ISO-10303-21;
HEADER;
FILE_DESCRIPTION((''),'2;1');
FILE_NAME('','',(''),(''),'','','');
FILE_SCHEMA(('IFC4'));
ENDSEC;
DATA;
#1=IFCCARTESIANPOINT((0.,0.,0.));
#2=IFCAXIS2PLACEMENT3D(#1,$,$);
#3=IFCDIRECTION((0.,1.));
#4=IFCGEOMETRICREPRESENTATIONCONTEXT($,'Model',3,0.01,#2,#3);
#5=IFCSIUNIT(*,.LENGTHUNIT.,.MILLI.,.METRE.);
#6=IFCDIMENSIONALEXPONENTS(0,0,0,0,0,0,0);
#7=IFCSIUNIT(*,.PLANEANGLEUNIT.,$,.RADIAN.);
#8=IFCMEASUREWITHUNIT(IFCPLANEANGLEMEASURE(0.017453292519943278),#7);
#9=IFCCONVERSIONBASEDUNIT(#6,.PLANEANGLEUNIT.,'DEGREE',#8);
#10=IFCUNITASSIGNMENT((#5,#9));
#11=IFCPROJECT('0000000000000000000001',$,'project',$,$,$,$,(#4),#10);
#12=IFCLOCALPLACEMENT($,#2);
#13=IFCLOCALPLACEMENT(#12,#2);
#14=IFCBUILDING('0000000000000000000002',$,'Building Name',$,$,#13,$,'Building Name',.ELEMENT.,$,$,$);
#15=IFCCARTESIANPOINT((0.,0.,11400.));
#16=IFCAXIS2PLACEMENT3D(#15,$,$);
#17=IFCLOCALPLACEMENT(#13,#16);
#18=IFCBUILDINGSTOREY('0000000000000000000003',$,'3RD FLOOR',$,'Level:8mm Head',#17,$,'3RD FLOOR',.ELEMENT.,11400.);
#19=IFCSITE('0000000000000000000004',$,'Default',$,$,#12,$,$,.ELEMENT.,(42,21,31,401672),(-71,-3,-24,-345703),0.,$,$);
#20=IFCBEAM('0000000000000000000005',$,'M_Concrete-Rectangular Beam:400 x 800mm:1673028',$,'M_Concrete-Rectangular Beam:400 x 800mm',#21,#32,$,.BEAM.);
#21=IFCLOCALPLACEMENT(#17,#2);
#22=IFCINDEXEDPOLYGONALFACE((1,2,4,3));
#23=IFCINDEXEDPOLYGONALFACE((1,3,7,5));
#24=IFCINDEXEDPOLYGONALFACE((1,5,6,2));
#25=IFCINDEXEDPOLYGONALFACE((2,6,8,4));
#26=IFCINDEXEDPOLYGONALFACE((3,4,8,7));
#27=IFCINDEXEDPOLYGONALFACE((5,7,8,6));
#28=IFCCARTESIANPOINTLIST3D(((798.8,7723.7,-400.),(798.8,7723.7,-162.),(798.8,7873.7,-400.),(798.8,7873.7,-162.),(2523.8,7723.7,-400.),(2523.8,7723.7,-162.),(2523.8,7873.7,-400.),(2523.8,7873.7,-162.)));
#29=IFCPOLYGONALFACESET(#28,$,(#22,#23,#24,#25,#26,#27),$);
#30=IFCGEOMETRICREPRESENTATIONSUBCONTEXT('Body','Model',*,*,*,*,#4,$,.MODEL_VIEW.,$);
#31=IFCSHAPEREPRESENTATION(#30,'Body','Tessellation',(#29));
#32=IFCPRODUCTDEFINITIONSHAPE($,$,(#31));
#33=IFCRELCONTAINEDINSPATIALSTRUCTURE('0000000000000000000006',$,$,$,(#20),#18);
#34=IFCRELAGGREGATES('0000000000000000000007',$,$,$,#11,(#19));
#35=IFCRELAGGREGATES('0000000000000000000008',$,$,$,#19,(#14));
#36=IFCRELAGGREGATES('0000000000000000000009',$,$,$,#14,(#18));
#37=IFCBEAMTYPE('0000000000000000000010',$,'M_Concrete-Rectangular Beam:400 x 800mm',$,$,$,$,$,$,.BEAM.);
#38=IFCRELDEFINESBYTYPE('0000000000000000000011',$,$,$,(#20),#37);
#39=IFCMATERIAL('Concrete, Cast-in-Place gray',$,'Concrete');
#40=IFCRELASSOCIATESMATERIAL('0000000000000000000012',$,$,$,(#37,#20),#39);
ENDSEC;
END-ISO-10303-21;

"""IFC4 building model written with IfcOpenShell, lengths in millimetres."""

from ifc_helpers import new_model, entity, si_unit, converted_unit, direction, frame, origin, place, context, subcontext, project, spatial, indexed_curve, outline, extrude, source, transform, mapped, material, type_object, type_shapes, element, save


model = new_model("IFC4")

# Units and contexts
model_context = context("Model", 3, precision=0.01, world=origin(), true_north=direction((0.0, 1.0)))
body_context = subcontext(model_context, "Body", "Model", "MODEL_VIEW")
ifc_project = project(units=[si_unit("LENGTHUNIT", "METRE", prefix="MILLI"), converted_unit("PLANEANGLEUNIT", "DEGREE", entity("IfcPlaneAngleMeasure", 0.017453292519943278), si_unit("PLANEANGLEUNIT", "RADIAN"), dimensions=[0, 0, 0, 0, 0, 0, 0])], contexts=[model_context])

# Site, building, storey
site_placement = place(None, origin())
site = spatial("IfcSite", under=ifc_project, at=site_placement, Name="Default", CompositionType="ELEMENT", RefLatitude=(42, 21, 31, 401672), RefLongitude=(-71, -3, -24, -345703), RefElevation=0.0)
building_placement = place(site_placement, origin())
building = spatial("IfcBuilding", under=site, at=building_placement, Name="Building Name", LongName="Building Name", CompositionType="ELEMENT")
storey_placement = place(building_placement, frame((0.0, 0.0, 11400.0)))
storey = spatial("IfcBuildingStorey", under=building, at=storey_placement, Name="3RD FLOOR", ObjectType="Level:8mm Head", LongName="3RD FLOOR", CompositionType="ELEMENT", Elevation=11400.0)

# Beam
ifc_material = material(Name="Concrete, Cast-in-Place gray", Category="Concrete")
beam_type_1 = type_object("IfcBeamType", Name="M_Concrete-Rectangular Beam:400 x 800mm", PredefinedType="BEAM", material=ifc_material)
shared_shape_1 = source(origin(), body_context, "Body", "SweptSolid", [
    extrude(outline(indexed_curve([(-119.0, -75.0), (119.0, -75.0), (119.0, 75.0), (-119.0, 75.0), (-119.0, -75.0)], self_intersect=False)), frame((798.8, 7798.7, 11119.0), z_axis=(1.0, 0.0, 0.0), x_axis=(0.0, 0.0, -1.0)), (0.0, 0.0, 1.0), 1725.0),
])
type_shapes(beam_type_1, [shared_shape_1])
beam_1_placement = place(storey_placement, frame((0.0, 0.0, -11400.0)))
element("IfcBeam", 1, at=beam_1_placement, inside=storey, type_object=beam_type_1, material=ifc_material, Name="M_Concrete-Rectangular Beam:400 x 800mm:1673028", ObjectType="M_Concrete-Rectangular Beam:400 x 800mm", PredefinedType="BEAM", context=body_context, shape_type="MappedRepresentation", body=[
    mapped(shared_shape_1, transform((0.0, 0.0, 0.0), scale=1.0)),
])

save(model, "model.ifc")
